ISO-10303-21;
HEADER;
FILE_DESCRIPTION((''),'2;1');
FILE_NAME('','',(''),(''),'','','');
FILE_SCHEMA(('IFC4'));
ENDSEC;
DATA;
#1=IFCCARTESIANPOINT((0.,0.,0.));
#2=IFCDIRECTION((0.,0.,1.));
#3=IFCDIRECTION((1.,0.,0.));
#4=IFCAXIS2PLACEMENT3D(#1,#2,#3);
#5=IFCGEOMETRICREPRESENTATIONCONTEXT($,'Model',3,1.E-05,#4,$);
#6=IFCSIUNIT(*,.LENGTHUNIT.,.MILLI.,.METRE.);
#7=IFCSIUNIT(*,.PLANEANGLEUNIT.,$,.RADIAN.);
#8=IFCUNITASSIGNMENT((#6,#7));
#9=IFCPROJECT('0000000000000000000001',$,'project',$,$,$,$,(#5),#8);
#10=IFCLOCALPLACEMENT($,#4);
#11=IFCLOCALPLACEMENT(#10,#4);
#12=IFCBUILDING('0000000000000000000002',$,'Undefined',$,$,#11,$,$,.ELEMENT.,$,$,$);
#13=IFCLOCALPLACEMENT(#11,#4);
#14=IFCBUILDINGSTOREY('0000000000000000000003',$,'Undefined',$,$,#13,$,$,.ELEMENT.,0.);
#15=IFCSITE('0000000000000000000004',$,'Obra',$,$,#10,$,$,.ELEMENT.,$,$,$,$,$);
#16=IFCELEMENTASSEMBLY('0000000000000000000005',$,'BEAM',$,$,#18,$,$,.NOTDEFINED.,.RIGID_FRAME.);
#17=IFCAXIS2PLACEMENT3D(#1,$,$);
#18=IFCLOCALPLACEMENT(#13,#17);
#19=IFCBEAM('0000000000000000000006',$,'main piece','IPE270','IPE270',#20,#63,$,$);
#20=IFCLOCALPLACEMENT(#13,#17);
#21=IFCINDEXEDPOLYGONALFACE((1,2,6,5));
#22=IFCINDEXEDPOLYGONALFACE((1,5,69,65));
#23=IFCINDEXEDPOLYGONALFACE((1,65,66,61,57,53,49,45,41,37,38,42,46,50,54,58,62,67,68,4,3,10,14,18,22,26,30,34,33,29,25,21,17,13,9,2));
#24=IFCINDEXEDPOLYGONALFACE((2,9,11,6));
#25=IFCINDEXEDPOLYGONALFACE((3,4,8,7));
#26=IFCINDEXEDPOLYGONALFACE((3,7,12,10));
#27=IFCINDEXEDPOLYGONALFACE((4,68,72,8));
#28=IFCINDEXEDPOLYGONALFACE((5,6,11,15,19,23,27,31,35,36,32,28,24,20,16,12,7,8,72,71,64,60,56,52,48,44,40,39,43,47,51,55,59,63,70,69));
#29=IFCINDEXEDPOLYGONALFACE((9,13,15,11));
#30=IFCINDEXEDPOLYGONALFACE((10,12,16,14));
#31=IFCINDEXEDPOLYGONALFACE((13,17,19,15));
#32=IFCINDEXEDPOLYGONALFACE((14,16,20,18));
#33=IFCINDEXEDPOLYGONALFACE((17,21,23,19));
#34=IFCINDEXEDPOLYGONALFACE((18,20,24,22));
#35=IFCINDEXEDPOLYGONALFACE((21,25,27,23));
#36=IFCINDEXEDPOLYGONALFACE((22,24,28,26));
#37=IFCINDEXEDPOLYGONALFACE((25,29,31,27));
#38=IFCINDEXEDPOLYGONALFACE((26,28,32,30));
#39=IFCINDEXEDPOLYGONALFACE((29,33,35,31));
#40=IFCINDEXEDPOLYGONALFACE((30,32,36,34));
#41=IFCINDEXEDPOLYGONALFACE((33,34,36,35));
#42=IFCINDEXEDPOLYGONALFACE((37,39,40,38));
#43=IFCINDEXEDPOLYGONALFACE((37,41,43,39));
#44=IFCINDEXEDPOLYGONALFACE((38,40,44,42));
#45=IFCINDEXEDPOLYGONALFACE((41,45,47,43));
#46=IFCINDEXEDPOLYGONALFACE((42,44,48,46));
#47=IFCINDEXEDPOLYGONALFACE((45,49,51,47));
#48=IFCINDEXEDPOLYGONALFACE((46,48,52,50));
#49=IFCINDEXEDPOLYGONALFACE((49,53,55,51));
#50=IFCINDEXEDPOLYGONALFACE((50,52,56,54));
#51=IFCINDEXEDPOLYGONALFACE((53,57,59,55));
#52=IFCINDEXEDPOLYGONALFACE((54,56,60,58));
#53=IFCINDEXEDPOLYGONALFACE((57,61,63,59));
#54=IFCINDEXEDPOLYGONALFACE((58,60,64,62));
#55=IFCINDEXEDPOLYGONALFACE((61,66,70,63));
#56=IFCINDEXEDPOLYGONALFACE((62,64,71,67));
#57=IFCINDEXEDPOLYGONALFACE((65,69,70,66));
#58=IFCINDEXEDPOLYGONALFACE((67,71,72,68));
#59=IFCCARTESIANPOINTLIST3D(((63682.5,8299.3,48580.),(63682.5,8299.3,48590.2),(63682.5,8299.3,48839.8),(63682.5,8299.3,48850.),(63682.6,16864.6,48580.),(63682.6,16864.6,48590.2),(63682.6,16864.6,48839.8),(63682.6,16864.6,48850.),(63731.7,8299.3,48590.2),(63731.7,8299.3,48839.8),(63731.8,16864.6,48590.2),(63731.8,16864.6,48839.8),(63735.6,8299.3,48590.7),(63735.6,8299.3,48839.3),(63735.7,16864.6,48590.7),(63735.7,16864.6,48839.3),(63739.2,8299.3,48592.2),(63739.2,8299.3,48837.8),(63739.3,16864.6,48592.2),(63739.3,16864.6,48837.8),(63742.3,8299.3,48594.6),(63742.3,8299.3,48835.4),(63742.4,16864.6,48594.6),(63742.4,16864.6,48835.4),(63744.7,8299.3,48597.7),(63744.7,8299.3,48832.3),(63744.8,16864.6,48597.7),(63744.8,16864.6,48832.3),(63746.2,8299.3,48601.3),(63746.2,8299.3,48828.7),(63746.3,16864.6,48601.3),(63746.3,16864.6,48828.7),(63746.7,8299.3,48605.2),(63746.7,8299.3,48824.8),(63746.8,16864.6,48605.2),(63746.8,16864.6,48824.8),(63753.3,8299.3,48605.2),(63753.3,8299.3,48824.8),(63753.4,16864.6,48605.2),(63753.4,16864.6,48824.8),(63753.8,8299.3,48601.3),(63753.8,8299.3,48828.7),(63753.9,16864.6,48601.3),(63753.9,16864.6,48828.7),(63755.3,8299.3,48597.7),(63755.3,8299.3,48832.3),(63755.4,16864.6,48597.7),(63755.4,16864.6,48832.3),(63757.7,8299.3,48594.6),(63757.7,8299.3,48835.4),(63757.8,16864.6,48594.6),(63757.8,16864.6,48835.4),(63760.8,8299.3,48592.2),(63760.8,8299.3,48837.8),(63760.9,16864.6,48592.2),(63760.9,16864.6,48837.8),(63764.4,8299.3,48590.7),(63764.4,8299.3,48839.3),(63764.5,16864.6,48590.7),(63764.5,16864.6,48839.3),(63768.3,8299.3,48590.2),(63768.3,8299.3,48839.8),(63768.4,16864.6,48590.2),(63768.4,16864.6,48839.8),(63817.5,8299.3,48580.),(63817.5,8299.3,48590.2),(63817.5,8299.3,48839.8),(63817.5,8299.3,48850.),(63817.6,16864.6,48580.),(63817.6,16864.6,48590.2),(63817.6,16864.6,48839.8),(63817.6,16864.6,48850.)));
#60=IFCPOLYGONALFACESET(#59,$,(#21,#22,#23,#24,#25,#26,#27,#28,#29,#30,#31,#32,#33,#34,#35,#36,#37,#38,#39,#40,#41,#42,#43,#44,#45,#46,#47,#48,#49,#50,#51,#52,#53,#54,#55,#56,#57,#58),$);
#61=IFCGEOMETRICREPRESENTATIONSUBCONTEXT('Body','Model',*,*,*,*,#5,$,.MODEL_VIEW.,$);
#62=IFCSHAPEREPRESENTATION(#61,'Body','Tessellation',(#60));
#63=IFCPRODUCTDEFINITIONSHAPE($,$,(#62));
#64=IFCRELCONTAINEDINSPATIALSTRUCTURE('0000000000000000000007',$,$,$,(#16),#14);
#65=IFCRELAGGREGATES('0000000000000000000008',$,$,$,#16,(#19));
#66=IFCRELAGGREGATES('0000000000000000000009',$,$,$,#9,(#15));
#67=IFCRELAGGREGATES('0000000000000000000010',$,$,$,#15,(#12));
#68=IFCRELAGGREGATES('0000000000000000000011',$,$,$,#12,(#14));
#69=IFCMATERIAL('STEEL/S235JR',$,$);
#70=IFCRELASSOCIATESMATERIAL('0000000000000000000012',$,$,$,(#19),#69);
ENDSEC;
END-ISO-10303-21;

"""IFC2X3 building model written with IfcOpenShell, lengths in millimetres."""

from ifc_helpers import new_model, si_unit, frame, origin_with_axes, origin_2d_with_axis, place, context, subcontext, project, spatial, i_section, extrude, material, element, aggregate, save


model = new_model("IFC2X3")

# Units and contexts
model_context = context("Model", 3, precision=1e-05, world=origin_with_axes())
body_context = subcontext(model_context, "Body", "Model", "MODEL_VIEW")
ifc_project = project(units=[si_unit("LENGTHUNIT", "METRE", prefix="MILLI"), si_unit("PLANEANGLEUNIT", "RADIAN")], contexts=[model_context])

# Site, building, storey
site_placement = place(None, origin_with_axes())
site = spatial("IfcSite", under=ifc_project, at=site_placement, Name="Obra", CompositionType="ELEMENT")
building_placement = place(site_placement, origin_with_axes())
building = spatial("IfcBuilding", under=site, at=building_placement, Name="Undefined", CompositionType="ELEMENT")
storey_placement = place(building_placement, origin_with_axes())
storey = spatial("IfcBuildingStorey", under=building, at=storey_placement, Name="Undefined", CompositionType="ELEMENT", Elevation=0.0)

# Shared definitions
ifc_material_1 = material(Name="STEEL/S235JR")

# Element assembly, beam
assembly_1_placement = place(storey_placement, origin_with_axes())
assembly_1 = element("IfcElementAssembly", 1, at=assembly_1_placement, inside=storey, Name="BEAM", AssemblyPlace="NOTDEFINED", PredefinedType="RIGID_FRAME")
beam_1_placement = place(assembly_1_placement, frame((63750.0, 8299.3, 48715.0), z_axis=(0.0, 0.0, 1.0), x_axis=(0.00001, 1.0, 0.0)))
beam_1 = element("IfcBeam", 2, at=beam_1_placement, material=ifc_material_1, Name="main piece", Description="IPE270", ObjectType="IPE270", context=body_context, shape_type="SweptSolid", body=[
    extrude(i_section(OverallWidth=135.0, OverallDepth=270.0, WebThickness=6.6, FlangeThickness=10.2, FilletRadius=15.0, at=origin_2d_with_axis()), frame((8565.3, 0.0, 0.0), z_axis=(-1.0, 0.0, 0.0), x_axis=(0.0, -1.0, 0.0)), (0.0, 0.0, 1.0), 8565.3),
])
aggregate(assembly_1, [beam_1])

save(model, "model.ifc")
